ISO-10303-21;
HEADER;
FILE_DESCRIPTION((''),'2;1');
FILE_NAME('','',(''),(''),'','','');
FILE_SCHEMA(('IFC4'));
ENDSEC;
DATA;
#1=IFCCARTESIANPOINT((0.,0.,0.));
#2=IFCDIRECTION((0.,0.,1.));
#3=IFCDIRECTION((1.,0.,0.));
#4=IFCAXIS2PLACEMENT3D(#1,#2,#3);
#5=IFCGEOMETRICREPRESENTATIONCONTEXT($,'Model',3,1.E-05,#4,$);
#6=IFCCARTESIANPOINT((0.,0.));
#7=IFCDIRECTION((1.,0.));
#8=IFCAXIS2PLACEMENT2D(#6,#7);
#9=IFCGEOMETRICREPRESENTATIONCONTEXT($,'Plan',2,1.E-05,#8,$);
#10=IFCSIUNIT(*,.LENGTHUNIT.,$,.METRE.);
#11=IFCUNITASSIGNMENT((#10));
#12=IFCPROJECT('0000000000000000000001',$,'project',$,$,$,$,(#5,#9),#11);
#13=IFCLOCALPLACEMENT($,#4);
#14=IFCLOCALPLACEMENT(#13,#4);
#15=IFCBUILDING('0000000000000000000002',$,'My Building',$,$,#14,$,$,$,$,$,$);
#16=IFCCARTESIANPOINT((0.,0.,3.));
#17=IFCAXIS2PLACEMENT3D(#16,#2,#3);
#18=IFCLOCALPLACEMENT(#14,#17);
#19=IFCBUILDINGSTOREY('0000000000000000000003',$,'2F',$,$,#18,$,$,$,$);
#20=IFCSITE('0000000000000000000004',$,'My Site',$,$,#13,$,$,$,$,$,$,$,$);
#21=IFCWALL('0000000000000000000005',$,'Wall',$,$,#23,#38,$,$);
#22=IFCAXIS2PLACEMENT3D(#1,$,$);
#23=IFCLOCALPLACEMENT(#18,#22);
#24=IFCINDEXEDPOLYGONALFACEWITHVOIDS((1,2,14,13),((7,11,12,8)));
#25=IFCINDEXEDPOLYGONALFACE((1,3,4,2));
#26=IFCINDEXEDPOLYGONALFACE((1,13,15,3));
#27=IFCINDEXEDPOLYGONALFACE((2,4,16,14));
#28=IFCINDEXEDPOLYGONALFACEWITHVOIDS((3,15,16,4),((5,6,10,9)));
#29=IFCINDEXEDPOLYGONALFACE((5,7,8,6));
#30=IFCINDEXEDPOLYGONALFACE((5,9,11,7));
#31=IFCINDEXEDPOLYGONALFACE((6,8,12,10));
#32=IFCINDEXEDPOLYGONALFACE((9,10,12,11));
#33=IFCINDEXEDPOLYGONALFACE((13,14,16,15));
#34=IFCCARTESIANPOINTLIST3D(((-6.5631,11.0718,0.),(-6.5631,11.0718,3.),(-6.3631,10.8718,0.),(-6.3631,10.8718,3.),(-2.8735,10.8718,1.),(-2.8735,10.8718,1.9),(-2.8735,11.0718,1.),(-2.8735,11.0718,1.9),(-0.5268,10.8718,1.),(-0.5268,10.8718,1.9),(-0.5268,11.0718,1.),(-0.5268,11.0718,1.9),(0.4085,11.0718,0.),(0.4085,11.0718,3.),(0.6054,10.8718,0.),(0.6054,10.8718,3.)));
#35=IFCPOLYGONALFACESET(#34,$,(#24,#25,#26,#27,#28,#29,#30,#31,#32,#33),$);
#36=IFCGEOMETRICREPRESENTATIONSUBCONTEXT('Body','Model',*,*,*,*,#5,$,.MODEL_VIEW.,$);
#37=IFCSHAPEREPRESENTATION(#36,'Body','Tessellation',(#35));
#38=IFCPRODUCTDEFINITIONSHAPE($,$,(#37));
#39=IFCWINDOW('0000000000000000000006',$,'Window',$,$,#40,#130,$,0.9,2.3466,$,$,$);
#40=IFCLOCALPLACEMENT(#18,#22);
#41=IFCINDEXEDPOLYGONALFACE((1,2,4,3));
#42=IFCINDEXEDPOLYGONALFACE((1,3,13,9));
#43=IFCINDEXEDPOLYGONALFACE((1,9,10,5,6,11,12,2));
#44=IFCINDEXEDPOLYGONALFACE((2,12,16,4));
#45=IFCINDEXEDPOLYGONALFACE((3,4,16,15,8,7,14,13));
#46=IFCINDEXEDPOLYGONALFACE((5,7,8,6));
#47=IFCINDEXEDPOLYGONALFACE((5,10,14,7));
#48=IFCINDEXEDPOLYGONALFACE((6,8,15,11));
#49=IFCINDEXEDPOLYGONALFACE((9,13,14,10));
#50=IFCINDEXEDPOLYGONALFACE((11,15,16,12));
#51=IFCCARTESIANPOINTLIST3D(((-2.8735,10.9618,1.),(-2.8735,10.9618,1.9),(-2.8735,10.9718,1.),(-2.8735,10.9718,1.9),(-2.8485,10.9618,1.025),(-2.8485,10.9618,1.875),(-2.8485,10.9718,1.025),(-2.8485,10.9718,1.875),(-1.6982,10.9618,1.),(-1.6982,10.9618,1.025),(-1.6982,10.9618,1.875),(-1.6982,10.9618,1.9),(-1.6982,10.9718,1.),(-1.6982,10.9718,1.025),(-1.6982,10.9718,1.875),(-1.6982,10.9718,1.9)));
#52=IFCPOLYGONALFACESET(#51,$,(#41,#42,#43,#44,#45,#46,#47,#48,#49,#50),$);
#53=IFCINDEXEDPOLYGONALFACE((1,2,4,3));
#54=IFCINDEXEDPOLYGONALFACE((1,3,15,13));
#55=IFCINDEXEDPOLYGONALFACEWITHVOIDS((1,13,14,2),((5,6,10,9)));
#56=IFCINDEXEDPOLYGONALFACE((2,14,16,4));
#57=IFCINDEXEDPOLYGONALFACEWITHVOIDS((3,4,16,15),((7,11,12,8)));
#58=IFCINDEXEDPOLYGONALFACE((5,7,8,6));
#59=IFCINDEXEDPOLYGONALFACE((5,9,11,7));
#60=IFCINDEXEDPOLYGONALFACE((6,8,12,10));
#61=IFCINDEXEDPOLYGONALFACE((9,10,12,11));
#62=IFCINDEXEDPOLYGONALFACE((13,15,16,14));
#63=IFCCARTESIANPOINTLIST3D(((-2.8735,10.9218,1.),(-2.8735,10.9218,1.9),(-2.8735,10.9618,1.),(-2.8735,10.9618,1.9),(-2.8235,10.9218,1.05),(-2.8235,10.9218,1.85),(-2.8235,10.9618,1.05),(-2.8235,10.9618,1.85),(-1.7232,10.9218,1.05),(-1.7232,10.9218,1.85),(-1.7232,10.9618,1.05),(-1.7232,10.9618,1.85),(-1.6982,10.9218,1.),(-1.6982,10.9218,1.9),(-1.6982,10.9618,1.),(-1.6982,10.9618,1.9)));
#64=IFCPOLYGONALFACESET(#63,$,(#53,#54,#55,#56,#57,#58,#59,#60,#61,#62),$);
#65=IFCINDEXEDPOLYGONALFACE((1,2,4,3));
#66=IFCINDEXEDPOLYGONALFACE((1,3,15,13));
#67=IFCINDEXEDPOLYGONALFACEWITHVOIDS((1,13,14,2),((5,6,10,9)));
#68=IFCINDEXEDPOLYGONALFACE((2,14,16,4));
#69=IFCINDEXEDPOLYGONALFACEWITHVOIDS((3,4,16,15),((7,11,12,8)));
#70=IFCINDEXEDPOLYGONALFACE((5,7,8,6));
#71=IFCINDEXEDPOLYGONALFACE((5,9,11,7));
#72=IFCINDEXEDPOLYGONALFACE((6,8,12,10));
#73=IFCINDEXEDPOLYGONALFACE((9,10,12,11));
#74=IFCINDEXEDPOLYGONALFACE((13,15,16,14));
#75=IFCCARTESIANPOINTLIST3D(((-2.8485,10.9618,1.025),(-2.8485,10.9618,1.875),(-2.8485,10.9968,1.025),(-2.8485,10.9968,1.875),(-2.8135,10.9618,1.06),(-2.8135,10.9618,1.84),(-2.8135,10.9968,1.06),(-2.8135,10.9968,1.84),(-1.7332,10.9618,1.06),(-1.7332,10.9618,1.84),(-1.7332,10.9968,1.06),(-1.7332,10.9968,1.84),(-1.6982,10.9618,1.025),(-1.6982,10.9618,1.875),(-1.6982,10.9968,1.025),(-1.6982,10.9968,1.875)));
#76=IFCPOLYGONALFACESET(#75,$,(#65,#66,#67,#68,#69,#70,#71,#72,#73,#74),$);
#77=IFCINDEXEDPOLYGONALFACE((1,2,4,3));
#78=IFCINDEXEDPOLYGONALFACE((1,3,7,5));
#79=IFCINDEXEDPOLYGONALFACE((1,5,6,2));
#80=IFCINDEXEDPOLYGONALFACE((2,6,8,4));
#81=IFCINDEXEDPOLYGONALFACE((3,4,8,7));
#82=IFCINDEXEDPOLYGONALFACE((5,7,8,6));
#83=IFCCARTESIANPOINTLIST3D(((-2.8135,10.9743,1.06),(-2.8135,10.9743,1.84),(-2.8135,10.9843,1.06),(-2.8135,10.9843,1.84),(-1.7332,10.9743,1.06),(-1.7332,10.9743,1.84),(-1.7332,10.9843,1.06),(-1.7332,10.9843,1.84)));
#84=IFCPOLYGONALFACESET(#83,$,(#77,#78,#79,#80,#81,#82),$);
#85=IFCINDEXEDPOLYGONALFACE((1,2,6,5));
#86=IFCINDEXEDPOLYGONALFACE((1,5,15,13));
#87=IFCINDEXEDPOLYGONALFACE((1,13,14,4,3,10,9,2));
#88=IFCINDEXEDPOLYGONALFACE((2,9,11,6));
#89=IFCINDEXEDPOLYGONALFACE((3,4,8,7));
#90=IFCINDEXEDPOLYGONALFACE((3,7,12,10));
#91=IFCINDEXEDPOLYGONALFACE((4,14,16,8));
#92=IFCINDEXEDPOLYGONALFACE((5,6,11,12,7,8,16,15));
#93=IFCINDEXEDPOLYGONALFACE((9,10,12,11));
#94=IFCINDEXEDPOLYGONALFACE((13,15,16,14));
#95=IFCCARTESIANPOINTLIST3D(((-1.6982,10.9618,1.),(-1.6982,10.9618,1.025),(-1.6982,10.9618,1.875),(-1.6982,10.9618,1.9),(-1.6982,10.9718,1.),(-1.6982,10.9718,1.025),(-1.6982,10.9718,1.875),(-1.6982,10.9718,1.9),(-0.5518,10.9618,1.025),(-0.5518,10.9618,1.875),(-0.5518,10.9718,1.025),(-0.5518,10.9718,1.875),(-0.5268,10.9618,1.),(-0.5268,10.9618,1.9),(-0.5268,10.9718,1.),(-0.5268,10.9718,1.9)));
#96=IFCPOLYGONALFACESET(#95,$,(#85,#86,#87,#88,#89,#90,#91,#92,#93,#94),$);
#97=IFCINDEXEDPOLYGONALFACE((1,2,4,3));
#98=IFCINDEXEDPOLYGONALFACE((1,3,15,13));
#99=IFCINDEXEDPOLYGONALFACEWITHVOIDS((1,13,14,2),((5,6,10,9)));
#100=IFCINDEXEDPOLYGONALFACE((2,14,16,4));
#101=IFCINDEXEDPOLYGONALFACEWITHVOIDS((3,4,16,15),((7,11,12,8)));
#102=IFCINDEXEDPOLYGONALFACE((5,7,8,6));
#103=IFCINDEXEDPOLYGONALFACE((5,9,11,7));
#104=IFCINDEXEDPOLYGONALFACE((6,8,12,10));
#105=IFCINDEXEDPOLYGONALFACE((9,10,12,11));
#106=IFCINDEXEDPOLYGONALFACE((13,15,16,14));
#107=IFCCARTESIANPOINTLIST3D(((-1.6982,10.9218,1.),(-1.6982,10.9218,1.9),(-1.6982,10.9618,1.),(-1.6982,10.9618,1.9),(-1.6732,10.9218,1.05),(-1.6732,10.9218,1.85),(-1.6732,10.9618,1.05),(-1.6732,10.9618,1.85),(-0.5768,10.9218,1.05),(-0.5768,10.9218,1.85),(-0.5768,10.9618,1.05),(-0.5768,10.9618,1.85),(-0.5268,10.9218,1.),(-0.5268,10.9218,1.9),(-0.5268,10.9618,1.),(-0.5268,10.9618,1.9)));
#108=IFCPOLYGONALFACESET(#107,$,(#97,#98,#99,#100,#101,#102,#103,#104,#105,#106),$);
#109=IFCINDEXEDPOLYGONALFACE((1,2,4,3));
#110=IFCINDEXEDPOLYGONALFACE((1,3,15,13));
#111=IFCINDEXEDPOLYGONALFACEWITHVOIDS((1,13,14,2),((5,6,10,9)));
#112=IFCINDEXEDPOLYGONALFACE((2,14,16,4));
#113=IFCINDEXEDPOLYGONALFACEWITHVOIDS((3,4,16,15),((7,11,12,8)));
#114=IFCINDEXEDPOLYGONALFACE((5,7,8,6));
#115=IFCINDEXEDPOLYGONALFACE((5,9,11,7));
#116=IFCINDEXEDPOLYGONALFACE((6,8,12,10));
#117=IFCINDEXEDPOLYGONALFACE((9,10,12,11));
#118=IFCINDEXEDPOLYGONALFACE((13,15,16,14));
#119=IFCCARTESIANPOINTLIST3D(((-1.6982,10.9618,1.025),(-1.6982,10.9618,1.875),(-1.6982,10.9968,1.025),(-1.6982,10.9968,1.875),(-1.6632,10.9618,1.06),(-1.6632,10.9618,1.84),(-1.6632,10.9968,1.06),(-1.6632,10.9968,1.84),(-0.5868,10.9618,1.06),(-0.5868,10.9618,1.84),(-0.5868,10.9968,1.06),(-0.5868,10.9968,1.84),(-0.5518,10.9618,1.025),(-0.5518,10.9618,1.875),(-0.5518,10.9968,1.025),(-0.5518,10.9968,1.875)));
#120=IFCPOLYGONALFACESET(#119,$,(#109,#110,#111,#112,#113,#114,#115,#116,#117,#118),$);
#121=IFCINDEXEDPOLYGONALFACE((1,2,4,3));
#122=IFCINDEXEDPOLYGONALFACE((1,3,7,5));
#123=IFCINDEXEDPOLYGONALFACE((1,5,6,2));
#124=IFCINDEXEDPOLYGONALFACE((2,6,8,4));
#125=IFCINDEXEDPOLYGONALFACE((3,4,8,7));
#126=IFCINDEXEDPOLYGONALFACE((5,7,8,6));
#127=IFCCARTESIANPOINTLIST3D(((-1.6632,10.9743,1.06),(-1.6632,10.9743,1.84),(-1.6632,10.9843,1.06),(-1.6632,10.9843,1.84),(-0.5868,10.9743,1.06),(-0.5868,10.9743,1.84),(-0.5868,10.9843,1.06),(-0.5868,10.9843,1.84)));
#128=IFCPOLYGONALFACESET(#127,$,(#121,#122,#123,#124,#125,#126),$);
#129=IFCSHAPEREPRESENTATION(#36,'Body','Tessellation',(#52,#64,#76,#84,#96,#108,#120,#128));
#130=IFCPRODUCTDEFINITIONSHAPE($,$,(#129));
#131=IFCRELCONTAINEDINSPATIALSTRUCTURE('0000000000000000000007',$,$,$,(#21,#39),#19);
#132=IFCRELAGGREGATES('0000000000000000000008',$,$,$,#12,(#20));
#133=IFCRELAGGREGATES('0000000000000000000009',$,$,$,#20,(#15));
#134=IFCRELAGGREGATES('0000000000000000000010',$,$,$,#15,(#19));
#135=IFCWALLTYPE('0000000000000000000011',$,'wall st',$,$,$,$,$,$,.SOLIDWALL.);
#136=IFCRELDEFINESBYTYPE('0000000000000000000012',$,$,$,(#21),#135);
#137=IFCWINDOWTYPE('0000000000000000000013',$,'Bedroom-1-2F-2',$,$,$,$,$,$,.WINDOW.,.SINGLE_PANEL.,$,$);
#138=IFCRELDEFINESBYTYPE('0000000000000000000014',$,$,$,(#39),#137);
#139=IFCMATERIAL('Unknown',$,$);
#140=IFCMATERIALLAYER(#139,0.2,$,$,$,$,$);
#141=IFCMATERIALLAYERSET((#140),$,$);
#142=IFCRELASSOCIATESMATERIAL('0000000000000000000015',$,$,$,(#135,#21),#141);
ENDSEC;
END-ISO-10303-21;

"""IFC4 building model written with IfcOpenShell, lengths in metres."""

from ifc_helpers import new_model, entity, si_unit, frame, origin_with_axes, origin_2d_with_axis, place, context, subcontext, project, spatial, line, indexed_curve, outline, extrude, shape, source, transform, mapped, material, layer, layer_set, layer_usage, type_object, type_shapes, element, fill, save


model = new_model("IFC4")

# Units and contexts
model_context = context("Model", 3, precision=1e-05, world=origin_with_axes())
plan_context = context("Plan", 2, precision=1e-05, world=origin_2d_with_axis())
body_context_1 = subcontext(model_context, "Body", "Model", "MODEL_VIEW")
body_context_2 = subcontext(plan_context, "Body", "Plan", "PLAN_VIEW")
ifc_project = project(units=[si_unit("LENGTHUNIT", "METRE")], contexts=[model_context, plan_context])

# Site, building, storey
site_placement = place(None, origin_with_axes())
site = spatial("IfcSite", under=ifc_project, at=site_placement, Name="My Site")
building_placement = place(site_placement, origin_with_axes())
building = spatial("IfcBuilding", under=site, at=building_placement, Name="My Building")
storey_placement = place(building_placement, frame((0.0, 0.0, 3.0), z_axis=(0.0, 0.0, 1.0), x_axis=(1.0, 0.0, 0.0)))
storey = spatial("IfcBuildingStorey", under=building, at=storey_placement, Name="2F")

# Shared definitions
ifc_material = material(Name="Unknown")

# Shared definitions
ifc_layer_1 = layer(ifc_material, 0.2)
ifc_layer_set_1 = layer_set([ifc_layer_1])
wall_type_1 = type_object("IfcWallType", Name="wall st", PredefinedType="SOLIDWALL", material=ifc_layer_set_1)

# Wall, opening, window
ifc_layer_usage_1 = layer_usage(ifc_layer_set_1, "AXIS2", "POSITIVE", 0.0)
wall_1_placement = place(storey_placement, frame((0.4085, 11.0718, 0.0), z_axis=(0.0, 0.0, 1.0), x_axis=(-1.0, 0.0, 0.0)))
wall_1 = element("IfcWall", 1, at=wall_1_placement, inside=storey, type_object=wall_type_1, material=ifc_layer_usage_1, Name="Wall", context=body_context_1, shape_type="SweptSolid", body=[
    extrude(outline(indexed_curve([(0.0, 0.0), (-0.1969, 0.2), (6.7716, 0.2), (6.9715, 0.0)], segments=[line(1, 2, 3, 4, 1)])), origin_with_axes(), (0.0, 0.0, 1.0), 3.0),
])
shared_shape_1 = source(origin_with_axes(), body_context_1, "Body", "SweptSolid", [
    extrude(outline(indexed_curve([(0.0, 0.0), (2.3466, 0.0), (2.3466, 0.9), (0.0, 0.9)], segments=[line(1, 2, 3, 4, 1)])), frame((0.0, -0.6, 0.0), z_axis=(0.0, -1.0, 0.0), x_axis=(1.0, 0.0, 0.0)), (0.0, 0.0, -1.0), 1.2),
])
opening_1_placement = place(wall_1_placement, frame((3.2819, 0.2, 1.0), z_axis=(0.0, 0.0, 1.0), x_axis=(-1.0, 0.0, 0.0)))
opening_1 = element("IfcOpeningElement", 2, at=opening_1_placement, cuts=wall_1, PredefinedType="OPENING", context=body_context_1, shape_type="MappedRepresentation", body=[
    mapped(shared_shape_1, transform((0.0, 0.0, 0.0), x_axis=(1.0, 0.0, 0.0), y_axis=(0.0, 1.0, 0.0), z_axis=(0.0, 0.0, 1.0), scale=1.0)),
])
window_type_1 = type_object("IfcWindowType", Name="Bedroom-1-2F-2", PartitioningType="SINGLE_PANEL", PredefinedType="WINDOW")
shared_shape_2 = source(origin_with_axes(), body_context_1, "Body", "SweptSolid", [
    extrude(outline(indexed_curve([(1.1752, 0.0), (0.0, 0.0), (0.0, 0.9), (1.1752, 0.9), (1.1752, 0.875), (0.025, 0.875), (0.025, 0.025), (1.1752, 0.025)], segments=[line(1, 2, 3, 4, 5, 6, 7, 8, 1)])), frame((0.0, 0.09, 0.0), z_axis=(0.0, -1.0, 0.0), x_axis=(1.0, 0.0, 0.0)), (0.0, 0.0, -1.0), 0.01),
    extrude(outline(indexed_curve([(0.0, 0.0), (1.1752, 0.0), (1.1752, 0.9), (0.0, 0.9)], segments=[line(1, 2, 3, 4, 1)]), holes=[indexed_curve([(0.05, 0.05), (1.1502, 0.05), (1.1502, 0.85), (0.05, 0.85)], segments=[line(1, 2, 3, 4, 1)])]), frame((0.0, 0.05, 0.0), z_axis=(0.0, -1.0, 0.0), x_axis=(1.0, 0.0, 0.0)), (0.0, 0.0, -1.0), 0.04),
    extrude(outline(indexed_curve([(0.0, 0.0), (1.1502, 0.0), (1.1502, 0.85), (0.0, 0.85)], segments=[line(1, 2, 3, 4, 1)]), holes=[indexed_curve([(0.035, 0.035), (1.1152, 0.035), (1.1152, 0.815), (0.035, 0.815)], segments=[line(1, 2, 3, 4, 1)])]), frame((0.025, 0.09, 0.025), z_axis=(0.0, -1.0, 0.0), x_axis=(1.0, 0.0, 0.0)), (0.0, 0.0, -1.0), 0.035),
    extrude(outline(indexed_curve([(0.035, 0.035), (1.1152, 0.035), (1.1152, 0.815), (0.035, 0.815)], segments=[line(1, 2, 3, 4, 1)])), frame((0.025, 0.1025, 0.025), z_axis=(0.0, -1.0, 0.0), x_axis=(1.0, 0.0, 0.0)), (0.0, 0.0, -1.0), 0.01),
    extrude(outline(indexed_curve([(0.0, 0.9), (1.1714, 0.9), (1.1714, 0.0), (0.0, 0.0), (0.0, 0.025), (1.1464, 0.025), (1.1464, 0.875), (0.0, 0.875)], segments=[line(1, 2, 3, 4, 5, 6, 7, 8, 1)])), frame((1.1752, 0.09, 0.0), z_axis=(0.0, -1.0, 0.0), x_axis=(1.0, 0.0, 0.0)), (0.0, 0.0, -1.0), 0.01),
    extrude(outline(indexed_curve([(0.0, 0.0), (1.1714, 0.0), (1.1714, 0.9), (0.0, 0.9)], segments=[line(1, 2, 3, 4, 1)]), holes=[indexed_curve([(0.025, 0.05), (1.1214, 0.05), (1.1214, 0.85), (0.025, 0.85)], segments=[line(1, 2, 3, 4, 1)])]), frame((1.1752, 0.05, 0.0), z_axis=(0.0, -1.0, 0.0), x_axis=(1.0, 0.0, 0.0)), (0.0, 0.0, -1.0), 0.04),
    extrude(outline(indexed_curve([(0.0, 0.0), (1.1464, 0.0), (1.1464, 0.85), (0.0, 0.85)], segments=[line(1, 2, 3, 4, 1)]), holes=[indexed_curve([(0.035, 0.035), (1.1114, 0.035), (1.1114, 0.815), (0.035, 0.815)], segments=[line(1, 2, 3, 4, 1)])]), frame((1.1752, 0.09, 0.025), z_axis=(0.0, -1.0, 0.0), x_axis=(1.0, 0.0, 0.0)), (0.0, 0.0, -1.0), 0.035),
    extrude(outline(indexed_curve([(0.035, 0.035), (1.1114, 0.035), (1.1114, 0.815), (0.035, 0.815)], segments=[line(1, 2, 3, 4, 1)])), frame((1.1752, 0.1025, 0.025), z_axis=(0.0, -1.0, 0.0), x_axis=(1.0, 0.0, 0.0)), (0.0, 0.0, -1.0), 0.01),
])
shared_shape_3 = source(origin_with_axes(), body_context_2, "Body", "Curve2D", [
    entity("IfcIndexedPolyCurve", entity("IfcCartesianPointList2D", [[0.05, 0.05], [1.1502, 0.05]])),
    entity("IfcIndexedPolyCurve", entity("IfcCartesianPointList2D", [[0.0, 0.1], [0.025, 0.1], [0.025, 0.09], [0.05, 0.09], [0.05, 0.05], [0.0, 0.05]]), [entity("IfcLineIndex", [1, 2, 3, 4, 5, 6, 1])]),
    entity("IfcIndexedPolyCurve", entity("IfcCartesianPointList2D", [[1.1752, 0.1], [1.1752, 0.1], [1.1752, 0.09], [1.1502, 0.09], [1.1502, 0.05], [1.1752, 0.05]])),
    entity("IfcIndexedPolyCurve", entity("IfcCartesianPointList2D", [[0.025, 0.09], [0.06, 0.09], [0.06, 0.125], [0.025, 0.125]]), [entity("IfcLineIndex", [1, 2, 3, 4, 1])]),
    entity("IfcIndexedPolyCurve", entity("IfcCartesianPointList2D", [[1.1752, 0.09], [1.1402, 0.09], [1.1402, 0.125], [1.1752, 0.125]]), [entity("IfcLineIndex", [1, 2, 3, 4, 1])]),
    entity("IfcIndexedPolyCurve", entity("IfcCartesianPointList2D", [[0.06, 0.09], [1.1402, 0.09]])),
    entity("IfcIndexedPolyCurve", entity("IfcCartesianPointList2D", [[0.06, 0.125], [1.1402, 0.125]])),
    entity("IfcIndexedPolyCurve", entity("IfcCartesianPointList2D", [[0.06, 0.1075], [1.1402, 0.1075]])),
    entity("IfcIndexedPolyCurve", entity("IfcCartesianPointList2D", [[1.2002, 0.05], [2.2966, 0.05]])),
    entity("IfcIndexedPolyCurve", entity("IfcCartesianPointList2D", [[1.1752, 0.1], [1.1752, 0.1], [1.1752, 0.09], [1.2002, 0.09], [1.2002, 0.05], [1.1752, 0.05]])),
    entity("IfcIndexedPolyCurve", entity("IfcCartesianPointList2D", [[2.3466, 0.1], [2.3216, 0.1], [2.3216, 0.09], [2.2966, 0.09], [2.2966, 0.05], [2.3466, 0.05]]), [entity("IfcLineIndex", [1, 2, 3, 4, 5, 6, 1])]),
    entity("IfcIndexedPolyCurve", entity("IfcCartesianPointList2D", [[1.1752, 0.09], [1.2102, 0.09], [1.2102, 0.125], [1.1752, 0.125]]), [entity("IfcLineIndex", [1, 2, 3, 4, 1])]),
    entity("IfcIndexedPolyCurve", entity("IfcCartesianPointList2D", [[2.3216, 0.09], [2.2866, 0.09], [2.2866, 0.125], [2.3216, 0.125]]), [entity("IfcLineIndex", [1, 2, 3, 4, 1])]),
    entity("IfcIndexedPolyCurve", entity("IfcCartesianPointList2D", [[1.2102, 0.09], [2.2866, 0.09]])),
    entity("IfcIndexedPolyCurve", entity("IfcCartesianPointList2D", [[1.2102, 0.125], [2.2866, 0.125]])),
    entity("IfcIndexedPolyCurve", entity("IfcCartesianPointList2D", [[1.2102, 0.1075], [2.2866, 0.1075]])),
])
type_shapes(window_type_1, [shared_shape_2, shared_shape_3])
window_1_placement = place(opening_1_placement, frame((0.0, 0.0, 0.0), z_axis=(0.0, 0.0, 1.0), x_axis=(1.0, 0.0, 0.0)))
window_1 = element("IfcWindow", 3, at=window_1_placement, inside=storey, type_object=window_type_1, Name="Window", OverallHeight=0.9, OverallWidth=2.3466, shapes=[
    shape(body_context_1, "Body", "MappedRepresentation", [mapped(shared_shape_2, transform((0.0, 0.0, 0.0), x_axis=(1.0, 0.0, 0.0), y_axis=(0.0, 1.0, 0.0), z_axis=(0.0, 0.0, 1.0), scale=1.0))]),
    shape(body_context_2, "Body", "MappedRepresentation", [mapped(shared_shape_3, transform((0.0, 0.0, 0.0), x_axis=(1.0, 0.0, 0.0), y_axis=(0.0, 1.0, 0.0), z_axis=(0.0, 0.0, 1.0), scale=1.0))]),
])
fill(opening_1, window_1)

save(model, "model.ifc")
